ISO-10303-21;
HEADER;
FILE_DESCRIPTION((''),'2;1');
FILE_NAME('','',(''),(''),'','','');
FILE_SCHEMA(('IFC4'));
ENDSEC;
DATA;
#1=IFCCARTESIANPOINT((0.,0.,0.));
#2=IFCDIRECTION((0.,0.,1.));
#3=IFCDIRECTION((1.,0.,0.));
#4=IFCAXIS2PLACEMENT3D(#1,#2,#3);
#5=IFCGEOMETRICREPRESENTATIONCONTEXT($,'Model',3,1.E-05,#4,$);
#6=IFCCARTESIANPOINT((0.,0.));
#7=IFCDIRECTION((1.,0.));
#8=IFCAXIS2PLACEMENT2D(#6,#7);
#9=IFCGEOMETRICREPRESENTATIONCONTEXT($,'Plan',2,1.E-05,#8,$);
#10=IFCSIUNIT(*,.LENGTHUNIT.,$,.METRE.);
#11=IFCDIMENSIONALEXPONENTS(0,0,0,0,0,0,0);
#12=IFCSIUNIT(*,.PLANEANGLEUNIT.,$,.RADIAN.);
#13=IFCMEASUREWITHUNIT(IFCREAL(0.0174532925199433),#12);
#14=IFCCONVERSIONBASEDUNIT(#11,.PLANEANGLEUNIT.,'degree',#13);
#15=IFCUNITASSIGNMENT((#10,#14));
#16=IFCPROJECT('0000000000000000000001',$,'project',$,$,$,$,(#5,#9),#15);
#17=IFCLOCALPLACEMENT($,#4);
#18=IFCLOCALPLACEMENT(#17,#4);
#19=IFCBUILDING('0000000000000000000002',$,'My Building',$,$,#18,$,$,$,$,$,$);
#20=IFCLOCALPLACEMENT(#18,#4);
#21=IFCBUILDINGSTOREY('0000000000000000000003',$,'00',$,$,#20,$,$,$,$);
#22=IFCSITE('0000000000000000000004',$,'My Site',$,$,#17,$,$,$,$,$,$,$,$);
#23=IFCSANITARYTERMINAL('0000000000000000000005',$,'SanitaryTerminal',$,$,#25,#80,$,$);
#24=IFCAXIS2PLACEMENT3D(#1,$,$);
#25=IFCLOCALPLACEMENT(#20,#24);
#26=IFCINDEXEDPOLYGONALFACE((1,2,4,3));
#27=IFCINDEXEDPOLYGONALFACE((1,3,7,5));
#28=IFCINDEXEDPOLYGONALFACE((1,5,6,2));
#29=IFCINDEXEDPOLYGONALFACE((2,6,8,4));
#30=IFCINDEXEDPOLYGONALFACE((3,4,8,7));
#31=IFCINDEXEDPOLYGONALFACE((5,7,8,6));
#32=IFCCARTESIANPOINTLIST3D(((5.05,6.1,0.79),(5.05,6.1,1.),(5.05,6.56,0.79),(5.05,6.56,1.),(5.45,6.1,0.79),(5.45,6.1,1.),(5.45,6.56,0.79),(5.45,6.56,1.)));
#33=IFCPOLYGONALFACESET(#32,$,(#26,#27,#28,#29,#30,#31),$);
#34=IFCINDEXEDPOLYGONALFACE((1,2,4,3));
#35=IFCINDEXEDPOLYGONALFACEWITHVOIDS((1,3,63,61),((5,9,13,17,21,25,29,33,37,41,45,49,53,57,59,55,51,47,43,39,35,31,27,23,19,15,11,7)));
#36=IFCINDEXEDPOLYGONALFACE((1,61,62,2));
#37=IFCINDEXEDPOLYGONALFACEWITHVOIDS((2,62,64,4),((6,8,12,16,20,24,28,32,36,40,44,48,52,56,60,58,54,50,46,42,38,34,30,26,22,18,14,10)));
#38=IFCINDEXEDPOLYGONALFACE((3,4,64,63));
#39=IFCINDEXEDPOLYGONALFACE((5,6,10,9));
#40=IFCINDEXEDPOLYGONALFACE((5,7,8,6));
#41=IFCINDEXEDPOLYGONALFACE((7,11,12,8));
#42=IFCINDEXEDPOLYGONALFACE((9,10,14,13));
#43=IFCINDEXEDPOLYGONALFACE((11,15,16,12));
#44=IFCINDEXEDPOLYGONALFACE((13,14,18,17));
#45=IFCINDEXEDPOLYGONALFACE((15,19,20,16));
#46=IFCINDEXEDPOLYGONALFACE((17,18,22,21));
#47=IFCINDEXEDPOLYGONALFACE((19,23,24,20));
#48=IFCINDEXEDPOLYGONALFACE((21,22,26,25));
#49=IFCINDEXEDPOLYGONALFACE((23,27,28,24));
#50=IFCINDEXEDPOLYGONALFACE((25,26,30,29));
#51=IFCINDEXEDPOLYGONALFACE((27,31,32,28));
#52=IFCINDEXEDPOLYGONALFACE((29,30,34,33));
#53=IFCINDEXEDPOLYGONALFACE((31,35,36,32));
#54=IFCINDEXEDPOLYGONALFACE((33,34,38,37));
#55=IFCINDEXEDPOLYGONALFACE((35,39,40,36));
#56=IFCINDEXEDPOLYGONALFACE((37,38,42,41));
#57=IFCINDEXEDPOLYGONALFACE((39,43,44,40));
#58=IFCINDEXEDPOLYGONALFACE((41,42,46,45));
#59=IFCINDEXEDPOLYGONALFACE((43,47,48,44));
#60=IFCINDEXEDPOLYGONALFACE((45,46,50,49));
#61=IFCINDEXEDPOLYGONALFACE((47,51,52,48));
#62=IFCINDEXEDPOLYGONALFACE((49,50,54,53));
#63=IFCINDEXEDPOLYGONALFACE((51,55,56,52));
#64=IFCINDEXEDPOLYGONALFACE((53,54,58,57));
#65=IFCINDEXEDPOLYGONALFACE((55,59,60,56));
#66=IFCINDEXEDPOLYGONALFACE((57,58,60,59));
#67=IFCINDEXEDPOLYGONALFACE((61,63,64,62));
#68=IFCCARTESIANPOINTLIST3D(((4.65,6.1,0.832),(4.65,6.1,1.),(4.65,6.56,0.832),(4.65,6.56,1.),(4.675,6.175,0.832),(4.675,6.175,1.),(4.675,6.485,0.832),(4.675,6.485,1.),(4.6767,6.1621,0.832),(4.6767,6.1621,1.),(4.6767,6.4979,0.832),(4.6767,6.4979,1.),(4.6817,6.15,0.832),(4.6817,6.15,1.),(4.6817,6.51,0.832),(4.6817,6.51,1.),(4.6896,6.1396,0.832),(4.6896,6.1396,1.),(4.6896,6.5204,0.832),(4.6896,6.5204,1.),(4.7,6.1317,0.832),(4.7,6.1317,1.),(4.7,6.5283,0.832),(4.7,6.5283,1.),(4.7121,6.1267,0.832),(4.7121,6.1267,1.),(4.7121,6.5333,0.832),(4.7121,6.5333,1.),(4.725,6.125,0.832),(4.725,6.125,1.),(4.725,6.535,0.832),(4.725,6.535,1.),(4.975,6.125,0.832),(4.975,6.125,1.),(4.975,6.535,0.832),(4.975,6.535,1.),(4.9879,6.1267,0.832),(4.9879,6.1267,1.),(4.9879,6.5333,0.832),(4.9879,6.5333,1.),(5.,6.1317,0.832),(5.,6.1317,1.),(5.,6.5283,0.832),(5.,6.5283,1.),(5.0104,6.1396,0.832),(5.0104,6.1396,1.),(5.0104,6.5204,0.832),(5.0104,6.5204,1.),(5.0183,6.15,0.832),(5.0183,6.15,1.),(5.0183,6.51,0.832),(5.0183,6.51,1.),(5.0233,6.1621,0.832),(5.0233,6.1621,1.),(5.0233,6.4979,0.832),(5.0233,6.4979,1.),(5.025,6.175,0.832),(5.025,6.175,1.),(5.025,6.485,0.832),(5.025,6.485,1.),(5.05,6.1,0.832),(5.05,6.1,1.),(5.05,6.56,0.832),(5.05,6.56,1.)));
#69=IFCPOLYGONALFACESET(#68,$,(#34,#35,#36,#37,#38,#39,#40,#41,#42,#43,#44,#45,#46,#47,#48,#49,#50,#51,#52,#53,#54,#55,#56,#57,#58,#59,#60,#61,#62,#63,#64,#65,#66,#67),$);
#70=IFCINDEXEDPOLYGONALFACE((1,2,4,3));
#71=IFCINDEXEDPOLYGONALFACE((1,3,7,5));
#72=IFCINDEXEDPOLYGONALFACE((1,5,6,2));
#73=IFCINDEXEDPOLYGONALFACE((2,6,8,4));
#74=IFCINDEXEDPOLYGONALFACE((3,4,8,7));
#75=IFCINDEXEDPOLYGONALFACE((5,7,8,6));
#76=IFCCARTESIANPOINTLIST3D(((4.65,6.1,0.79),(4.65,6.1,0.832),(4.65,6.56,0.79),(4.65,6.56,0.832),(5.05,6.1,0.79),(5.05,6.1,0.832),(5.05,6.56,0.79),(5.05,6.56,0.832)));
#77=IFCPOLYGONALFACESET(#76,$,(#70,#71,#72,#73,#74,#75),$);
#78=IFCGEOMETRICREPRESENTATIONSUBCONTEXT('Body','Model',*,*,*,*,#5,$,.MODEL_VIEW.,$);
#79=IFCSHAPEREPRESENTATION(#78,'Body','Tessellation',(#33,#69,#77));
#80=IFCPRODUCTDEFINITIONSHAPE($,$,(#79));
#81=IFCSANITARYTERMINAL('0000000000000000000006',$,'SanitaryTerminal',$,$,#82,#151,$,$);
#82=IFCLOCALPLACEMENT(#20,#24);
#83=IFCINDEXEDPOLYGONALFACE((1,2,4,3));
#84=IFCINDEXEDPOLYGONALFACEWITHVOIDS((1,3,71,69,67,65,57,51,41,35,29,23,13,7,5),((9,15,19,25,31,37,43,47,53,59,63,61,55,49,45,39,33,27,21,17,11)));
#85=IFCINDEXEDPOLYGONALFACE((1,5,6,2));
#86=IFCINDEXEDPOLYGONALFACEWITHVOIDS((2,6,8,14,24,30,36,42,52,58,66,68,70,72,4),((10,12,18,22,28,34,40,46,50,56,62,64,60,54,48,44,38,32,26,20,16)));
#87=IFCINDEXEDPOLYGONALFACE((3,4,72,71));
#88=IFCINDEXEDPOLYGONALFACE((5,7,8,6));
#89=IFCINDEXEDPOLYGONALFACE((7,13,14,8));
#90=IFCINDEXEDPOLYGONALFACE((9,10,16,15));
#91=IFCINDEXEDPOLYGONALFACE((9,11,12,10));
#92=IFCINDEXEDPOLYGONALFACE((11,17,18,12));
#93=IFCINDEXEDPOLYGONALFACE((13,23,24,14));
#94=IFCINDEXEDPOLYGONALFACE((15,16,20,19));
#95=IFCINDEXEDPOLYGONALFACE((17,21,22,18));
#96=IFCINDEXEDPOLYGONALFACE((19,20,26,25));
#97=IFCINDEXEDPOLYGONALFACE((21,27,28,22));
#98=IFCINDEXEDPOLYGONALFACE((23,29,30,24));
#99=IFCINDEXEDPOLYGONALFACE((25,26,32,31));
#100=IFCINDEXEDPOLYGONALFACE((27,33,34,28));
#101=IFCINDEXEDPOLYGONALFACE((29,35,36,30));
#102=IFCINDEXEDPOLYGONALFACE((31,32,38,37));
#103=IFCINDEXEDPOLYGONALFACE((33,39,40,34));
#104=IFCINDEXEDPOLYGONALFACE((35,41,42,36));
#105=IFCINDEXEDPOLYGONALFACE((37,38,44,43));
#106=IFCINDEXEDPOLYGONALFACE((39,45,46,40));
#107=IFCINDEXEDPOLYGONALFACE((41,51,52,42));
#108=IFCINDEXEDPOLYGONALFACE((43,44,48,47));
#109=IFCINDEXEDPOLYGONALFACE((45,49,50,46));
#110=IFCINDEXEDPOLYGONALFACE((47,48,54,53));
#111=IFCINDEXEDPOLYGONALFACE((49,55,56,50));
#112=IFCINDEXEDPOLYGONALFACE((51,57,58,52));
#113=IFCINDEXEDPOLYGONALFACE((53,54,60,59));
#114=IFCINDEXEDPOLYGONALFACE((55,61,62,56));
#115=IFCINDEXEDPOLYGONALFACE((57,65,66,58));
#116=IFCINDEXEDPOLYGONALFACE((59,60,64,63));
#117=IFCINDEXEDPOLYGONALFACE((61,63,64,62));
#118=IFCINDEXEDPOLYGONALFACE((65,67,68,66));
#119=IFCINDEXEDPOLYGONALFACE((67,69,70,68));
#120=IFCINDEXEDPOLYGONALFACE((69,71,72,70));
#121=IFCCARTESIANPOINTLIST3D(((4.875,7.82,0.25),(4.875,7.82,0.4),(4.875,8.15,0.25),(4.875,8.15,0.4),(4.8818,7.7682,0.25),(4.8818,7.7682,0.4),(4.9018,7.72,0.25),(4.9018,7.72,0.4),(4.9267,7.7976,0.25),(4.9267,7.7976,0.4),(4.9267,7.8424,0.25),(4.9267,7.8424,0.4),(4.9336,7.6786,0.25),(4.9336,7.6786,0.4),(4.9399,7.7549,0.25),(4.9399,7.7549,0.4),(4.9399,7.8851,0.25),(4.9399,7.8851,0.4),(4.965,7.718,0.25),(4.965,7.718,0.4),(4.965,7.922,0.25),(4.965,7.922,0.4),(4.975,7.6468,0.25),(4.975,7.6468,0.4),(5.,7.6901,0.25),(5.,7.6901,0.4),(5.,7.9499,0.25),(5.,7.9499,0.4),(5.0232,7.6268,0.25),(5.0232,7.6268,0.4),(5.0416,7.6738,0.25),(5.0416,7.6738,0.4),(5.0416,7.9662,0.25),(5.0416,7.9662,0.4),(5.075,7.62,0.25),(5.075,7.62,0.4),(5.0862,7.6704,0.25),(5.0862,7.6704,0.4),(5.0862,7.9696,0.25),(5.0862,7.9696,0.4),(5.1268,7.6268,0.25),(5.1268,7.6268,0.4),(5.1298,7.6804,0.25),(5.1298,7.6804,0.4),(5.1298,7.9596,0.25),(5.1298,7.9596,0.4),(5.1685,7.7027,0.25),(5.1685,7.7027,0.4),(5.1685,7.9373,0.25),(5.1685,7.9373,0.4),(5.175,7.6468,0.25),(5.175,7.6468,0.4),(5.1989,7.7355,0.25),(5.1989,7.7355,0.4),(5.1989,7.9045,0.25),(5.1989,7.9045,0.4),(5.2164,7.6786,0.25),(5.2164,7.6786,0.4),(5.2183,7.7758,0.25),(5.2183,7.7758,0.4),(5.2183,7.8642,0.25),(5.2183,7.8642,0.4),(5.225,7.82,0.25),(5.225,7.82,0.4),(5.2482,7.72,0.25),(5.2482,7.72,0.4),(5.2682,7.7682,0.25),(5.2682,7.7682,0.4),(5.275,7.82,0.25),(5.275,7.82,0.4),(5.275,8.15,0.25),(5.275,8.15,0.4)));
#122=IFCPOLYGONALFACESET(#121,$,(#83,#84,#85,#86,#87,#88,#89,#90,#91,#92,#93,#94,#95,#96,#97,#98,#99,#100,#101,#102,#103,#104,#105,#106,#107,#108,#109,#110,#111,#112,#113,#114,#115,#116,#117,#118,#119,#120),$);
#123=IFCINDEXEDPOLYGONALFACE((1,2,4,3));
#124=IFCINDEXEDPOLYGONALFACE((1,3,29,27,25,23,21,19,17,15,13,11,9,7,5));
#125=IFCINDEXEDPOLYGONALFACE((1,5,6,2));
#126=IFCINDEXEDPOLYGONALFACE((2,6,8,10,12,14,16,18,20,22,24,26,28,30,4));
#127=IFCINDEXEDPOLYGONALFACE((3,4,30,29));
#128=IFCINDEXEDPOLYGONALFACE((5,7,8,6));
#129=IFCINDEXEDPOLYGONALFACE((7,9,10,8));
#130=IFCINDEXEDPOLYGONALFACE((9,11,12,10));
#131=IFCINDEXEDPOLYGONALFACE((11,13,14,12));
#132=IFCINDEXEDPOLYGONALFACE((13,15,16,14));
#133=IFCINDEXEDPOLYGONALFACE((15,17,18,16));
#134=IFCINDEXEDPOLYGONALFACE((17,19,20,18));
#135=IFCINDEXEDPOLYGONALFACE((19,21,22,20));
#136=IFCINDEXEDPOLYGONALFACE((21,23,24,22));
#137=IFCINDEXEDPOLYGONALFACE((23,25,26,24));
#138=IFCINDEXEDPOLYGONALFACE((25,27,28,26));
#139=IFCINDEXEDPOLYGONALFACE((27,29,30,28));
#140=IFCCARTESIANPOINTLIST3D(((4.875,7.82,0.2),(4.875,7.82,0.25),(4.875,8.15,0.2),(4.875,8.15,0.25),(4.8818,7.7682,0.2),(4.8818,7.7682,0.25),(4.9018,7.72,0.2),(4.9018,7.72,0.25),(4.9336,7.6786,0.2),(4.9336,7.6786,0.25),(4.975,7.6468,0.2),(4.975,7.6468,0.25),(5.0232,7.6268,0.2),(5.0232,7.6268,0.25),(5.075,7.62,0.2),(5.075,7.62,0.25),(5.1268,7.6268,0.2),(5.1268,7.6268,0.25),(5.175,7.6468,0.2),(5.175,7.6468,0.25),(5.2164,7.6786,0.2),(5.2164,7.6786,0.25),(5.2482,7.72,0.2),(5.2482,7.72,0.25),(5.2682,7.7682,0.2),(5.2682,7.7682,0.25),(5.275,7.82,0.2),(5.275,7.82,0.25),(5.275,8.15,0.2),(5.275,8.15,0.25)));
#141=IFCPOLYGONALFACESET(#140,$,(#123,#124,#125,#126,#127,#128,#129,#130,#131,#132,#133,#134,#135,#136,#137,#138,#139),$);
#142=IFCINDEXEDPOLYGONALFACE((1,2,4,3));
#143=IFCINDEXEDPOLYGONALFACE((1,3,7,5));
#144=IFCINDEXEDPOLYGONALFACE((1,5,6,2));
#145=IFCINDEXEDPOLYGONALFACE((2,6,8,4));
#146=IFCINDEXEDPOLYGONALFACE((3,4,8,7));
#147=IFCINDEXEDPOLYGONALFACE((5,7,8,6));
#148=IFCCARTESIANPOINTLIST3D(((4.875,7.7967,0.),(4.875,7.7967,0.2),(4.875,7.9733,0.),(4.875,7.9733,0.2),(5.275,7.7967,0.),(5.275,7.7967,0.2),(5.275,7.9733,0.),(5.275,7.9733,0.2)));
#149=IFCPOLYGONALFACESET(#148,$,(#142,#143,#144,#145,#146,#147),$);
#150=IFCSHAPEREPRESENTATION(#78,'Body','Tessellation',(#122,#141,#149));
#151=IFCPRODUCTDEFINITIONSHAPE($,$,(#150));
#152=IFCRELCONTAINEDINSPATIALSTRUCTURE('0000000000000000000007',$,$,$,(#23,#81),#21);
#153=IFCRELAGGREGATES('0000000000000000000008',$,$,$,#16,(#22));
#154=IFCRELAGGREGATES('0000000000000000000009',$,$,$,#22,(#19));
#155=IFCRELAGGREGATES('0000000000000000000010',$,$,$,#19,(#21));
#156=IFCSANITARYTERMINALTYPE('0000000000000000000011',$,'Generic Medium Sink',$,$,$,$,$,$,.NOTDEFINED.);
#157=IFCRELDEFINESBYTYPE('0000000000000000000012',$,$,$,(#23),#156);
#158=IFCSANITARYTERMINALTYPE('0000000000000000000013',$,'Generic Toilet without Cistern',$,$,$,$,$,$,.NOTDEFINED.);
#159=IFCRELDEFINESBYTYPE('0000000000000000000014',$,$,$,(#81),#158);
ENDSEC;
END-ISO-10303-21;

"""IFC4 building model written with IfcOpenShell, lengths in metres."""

from ifc_helpers import new_model, entity, si_unit, converted_unit, frame, frame_2d, origin_with_axes, origin_2d_with_axis, place, context, subcontext, project, spatial, line, arc, indexed_curve, circle_curve, outline, extrude, shape, source, transform, mapped, type_object, type_shapes, element, save


model = new_model("IFC4")

# Units and contexts
model_context = context("Model", 3, precision=1e-05, world=origin_with_axes())
plan_context = context("Plan", 2, precision=1e-05, world=origin_2d_with_axis())
body_context_1 = subcontext(model_context, "Body", "Model", "MODEL_VIEW")
body_context_2 = subcontext(plan_context, "Body", "Plan", "PLAN_VIEW")
ifc_project = project(units=[si_unit("LENGTHUNIT", "METRE"), converted_unit("PLANEANGLEUNIT", "degree", entity("IfcReal", 0.0174532925199433), si_unit("PLANEANGLEUNIT", "RADIAN"), dimensions=[0, 0, 0, 0, 0, 0, 0])], contexts=[model_context, plan_context])

# Site, building, storey
site_placement = place(None, origin_with_axes())
site = spatial("IfcSite", under=ifc_project, at=site_placement, Name="My Site")
building_placement = place(site_placement, origin_with_axes())
building = spatial("IfcBuilding", under=site, at=building_placement, Name="My Building")
storey_placement = place(building_placement, origin_with_axes())
storey = spatial("IfcBuildingStorey", under=building, at=storey_placement, Name="00")

# Sanitary terminals
sanitary_terminal_type_1 = type_object("IfcSanitaryTerminalType", Name="Generic Medium Sink", PredefinedType="NOTDEFINED")
shared_indexed_poly_curve = entity("IfcIndexedPolyCurve", entity("IfcCartesianPointList2D", [[0.4, 0.0], [0.8, 0.0], [0.8, 0.46], [0.4, 0.46]]), [entity("IfcLineIndex", [1, 2, 3, 4, 1])])
shared_shape_1 = source(origin_with_axes(), body_context_1, "Body", "SweptSolid", [
    extrude(outline(indexed_curve([(0.0, 0.0), (0.4, 0.0), (0.4, 0.46), (0.0, 0.46)], segments=[line(1, 2, 3, 4, 1)])), frame((-0.4, -0.46, 0.0), z_axis=(0.0, 0.0, 1.0), x_axis=(1.0, 0.0, 0.0)), (0.0, 0.0, 1.0), 0.21),
    entity("IfcExtrudedAreaSolid", entity("IfcArbitraryProfileDefWithVoids", "AREA", None, shared_indexed_poly_curve, [entity("IfcIndexedPolyCurve", entity("IfcCartesianPointList2D", [[0.425, 0.075], [0.4396, 0.0396], [0.475, 0.025], [0.725, 0.025], [0.7604, 0.0396], [0.775, 0.075], [0.775, 0.385], [0.7604, 0.4204], [0.725, 0.435], [0.475, 0.435], [0.4396, 0.4204], [0.425, 0.385]]), [entity("IfcLineIndex", [12, 1]), entity("IfcArcIndex", [1, 2, 3]), entity("IfcLineIndex", [3, 4]), entity("IfcArcIndex", [4, 5, 6]), entity("IfcLineIndex", [6, 7]), entity("IfcArcIndex", [7, 8, 9]), entity("IfcLineIndex", [9, 10]), entity("IfcArcIndex", [10, 11, 12]), entity("IfcLineIndex", [12, 1])])]), entity("IfcAxis2Placement3D", entity("IfcCartesianPoint", [-0.4, -0.46, 0.042]), entity("IfcDirection", [0.0, 0.0, 1.0]), entity("IfcDirection", [1.0, 0.0, 0.0])), entity("IfcDirection", [0.0, 0.0, 1.0]), 0.168),
    entity("IfcExtrudedAreaSolid", entity("IfcArbitraryClosedProfileDef", "AREA", None, shared_indexed_poly_curve), entity("IfcAxis2Placement3D", entity("IfcCartesianPoint", [-0.4, -0.46, 0.0]), entity("IfcDirection", [0.0, 0.0, 1.0]), entity("IfcDirection", [1.0, 0.0, 0.0])), entity("IfcDirection", [0.0, 0.0, 1.0]), 0.042),
])
shared_shape_2 = source(origin_with_axes(), body_context_2, "Body", "Curve2D", [
    entity("IfcIndexedPolyCurve", entity("IfcCartesianPointList2D", [[-0.4, -0.46], [0.4, -0.46], [0.4, 0.0], [-0.4, 0.0]]), [entity("IfcLineIndex", [1, 2, 3, 4, 1])]),
    entity("IfcIndexedPolyCurve", entity("IfcCartesianPointList2D", [[0.025, -0.385], [0.0396, -0.4204], [0.075, -0.435], [0.325, -0.435], [0.3604, -0.4204], [0.375, -0.385], [0.375, -0.075], [0.3604, -0.0396], [0.325, -0.025], [0.075, -0.025], [0.0396, -0.0396], [0.025, -0.075]]), [entity("IfcLineIndex", [12, 1]), entity("IfcArcIndex", [1, 2, 3]), entity("IfcLineIndex", [3, 4]), entity("IfcArcIndex", [4, 5, 6]), entity("IfcLineIndex", [6, 7]), entity("IfcArcIndex", [7, 8, 9]), entity("IfcLineIndex", [9, 10]), entity("IfcArcIndex", [10, 11, 12]), entity("IfcLineIndex", [12, 1])]),
    entity("IfcCircle", entity("IfcAxis2Placement2D", entity("IfcCartesianPoint", [0.2, -0.125])), 0.025),
    entity("IfcIndexedPolyCurve", entity("IfcCartesianPointList2D", [[0.2, -0.0125], [0.2, -0.1325]])),
])
type_shapes(sanitary_terminal_type_1, [shared_shape_1, shared_shape_2])
sanitary_terminal_1_placement = place(storey_placement, frame((5.05, 6.1, 0.79), z_axis=(0.0, 0.0, 1.0), x_axis=(-1.0, 0.0, 0.0)))
element("IfcSanitaryTerminal", 1, at=sanitary_terminal_1_placement, inside=storey, type_object=sanitary_terminal_type_1, Name="SanitaryTerminal", shapes=[
    shape(body_context_1, "Body", "MappedRepresentation", [mapped(shared_shape_1, transform((0.0, 0.0, 0.0), x_axis=(1.0, 0.0, 0.0), y_axis=(0.0, 1.0, 0.0), z_axis=(0.0, 0.0, 1.0), scale=1.0))]),
    shape(body_context_2, "Body", "MappedRepresentation", [mapped(shared_shape_2, transform((0.0, 0.0, 0.0), x_axis=(1.0, 0.0, 0.0), y_axis=(0.0, 1.0, 0.0), z_axis=(0.0, 0.0, 1.0), scale=1.0))]),
])
sanitary_terminal_type_2 = type_object("IfcSanitaryTerminalType", Name="Generic Toilet without Cistern", PredefinedType="NOTDEFINED")
shared_shape_3 = source(origin_with_axes(), body_context_1, "Body", "SweptSolid", [
    extrude(outline(indexed_curve([(-0.2, 0.0), (0.2, 0.0), (0.2, -0.33), (0.1414, -0.4714), (0.0, -0.53), (-0.1414, -0.4714), (-0.2, -0.33)], segments=[line(1, 2), line(2, 3), arc(3, 4, 5), arc(5, 6, 7), line(7, 1)]), holes=[circle_curve(frame_2d((0.0, -0.33)), 0.15)]), frame((0.0, 0.0, 0.25), z_axis=(0.0, 0.0, 1.0), x_axis=(1.0, 0.0, 0.0)), (0.0, 0.0, 1.0), 0.15),
    extrude(outline(indexed_curve([(-0.2, 0.0), (0.2, 0.0), (0.2, -0.33), (0.1414, -0.4714), (0.0, -0.53), (-0.1414, -0.4714), (-0.2, -0.33)], segments=[line(1, 2), line(2, 3), arc(3, 4, 5), arc(5, 6, 7), line(7, 1)])), frame((0.0, 0.0, 0.2), z_axis=(0.0, 0.0, 1.0), x_axis=(1.0, 0.0, 0.0)), (0.0, 0.0, 1.0), 0.05),
    extrude(outline(indexed_curve([(-0.2, -0.1767), (0.2, -0.1767), (0.2, -0.3533), (-0.2, -0.3533)], segments=[line(1, 2, 3, 4, 1)])), origin_with_axes(), (0.0, 0.0, 1.0), 0.2),
])
shared_shape_4 = source(origin_with_axes(), body_context_2, "Body", "Curve2D", [
    entity("IfcIndexedPolyCurve", entity("IfcCartesianPointList2D", [[-0.12, 0.0], [0.12, 0.0]])),
    entity("IfcIndexedPolyCurve", entity("IfcCartesianPointList2D", [[0.12, 0.0], [0.2, -0.159]])),
    entity("IfcTrimmedCurve", entity("IfcEllipse", entity("IfcAxis2Placement2D", entity("IfcCartesianPoint", [0.0, -0.159]), entity("IfcDirection", [1.0, 0.0])), 0.2, 0.371), [entity("IfcCartesianPoint", [-0.2, -0.159])], [entity("IfcCartesianPoint", [0.2, -0.159])], True, "CARTESIAN"),
    entity("IfcIndexedPolyCurve", entity("IfcCartesianPointList2D", [[-0.12, 0.0], [-0.2, -0.159]])),
    entity("IfcEllipse", entity("IfcAxis2Placement2D", entity("IfcCartesianPoint", [0.0, -0.2968]), entity("IfcDirection", [1.0, 0.0])), 0.15, 0.1855),
    entity("IfcIndexedPolyCurve", entity("IfcCartesianPointList2D", [[-0.025, -0.2968], [-0.025, -0.2703], [0.025, -0.2703], [0.025, -0.2968]])),
    entity("IfcTrimmedCurve", entity("IfcEllipse", entity("IfcAxis2Placement2D", entity("IfcCartesianPoint", [0.0, -0.2968]), entity("IfcDirection", [1.0, 0.0])), 0.025, 0.0265), [entity("IfcCartesianPoint", [-0.025, -0.2968])], [entity("IfcCartesianPoint", [0.025, -0.2968])], True, "CARTESIAN"),
])
type_shapes(sanitary_terminal_type_2, [shared_shape_3, shared_shape_4])
sanitary_terminal_2_placement = place(storey_placement, frame((5.075, 8.15, 0.0), z_axis=(0.0, 0.0, 1.0), x_axis=(1.0, 0.0, 0.0)))
element("IfcSanitaryTerminal", 2, at=sanitary_terminal_2_placement, inside=storey, type_object=sanitary_terminal_type_2, Name="SanitaryTerminal", shapes=[
    shape(body_context_1, "Body", "MappedRepresentation", [mapped(shared_shape_3, transform((0.0, 0.0, 0.0), x_axis=(1.0, 0.0, 0.0), y_axis=(0.0, 1.0, 0.0), z_axis=(0.0, 0.0, 1.0), scale=1.0))]),
    shape(body_context_2, "Body", "MappedRepresentation", [mapped(shared_shape_4, transform((0.0, 0.0, 0.0), x_axis=(1.0, 0.0, 0.0), y_axis=(0.0, 1.0, 0.0), z_axis=(0.0, 0.0, 1.0), scale=1.0))]),
])

save(model, "model.ifc")
